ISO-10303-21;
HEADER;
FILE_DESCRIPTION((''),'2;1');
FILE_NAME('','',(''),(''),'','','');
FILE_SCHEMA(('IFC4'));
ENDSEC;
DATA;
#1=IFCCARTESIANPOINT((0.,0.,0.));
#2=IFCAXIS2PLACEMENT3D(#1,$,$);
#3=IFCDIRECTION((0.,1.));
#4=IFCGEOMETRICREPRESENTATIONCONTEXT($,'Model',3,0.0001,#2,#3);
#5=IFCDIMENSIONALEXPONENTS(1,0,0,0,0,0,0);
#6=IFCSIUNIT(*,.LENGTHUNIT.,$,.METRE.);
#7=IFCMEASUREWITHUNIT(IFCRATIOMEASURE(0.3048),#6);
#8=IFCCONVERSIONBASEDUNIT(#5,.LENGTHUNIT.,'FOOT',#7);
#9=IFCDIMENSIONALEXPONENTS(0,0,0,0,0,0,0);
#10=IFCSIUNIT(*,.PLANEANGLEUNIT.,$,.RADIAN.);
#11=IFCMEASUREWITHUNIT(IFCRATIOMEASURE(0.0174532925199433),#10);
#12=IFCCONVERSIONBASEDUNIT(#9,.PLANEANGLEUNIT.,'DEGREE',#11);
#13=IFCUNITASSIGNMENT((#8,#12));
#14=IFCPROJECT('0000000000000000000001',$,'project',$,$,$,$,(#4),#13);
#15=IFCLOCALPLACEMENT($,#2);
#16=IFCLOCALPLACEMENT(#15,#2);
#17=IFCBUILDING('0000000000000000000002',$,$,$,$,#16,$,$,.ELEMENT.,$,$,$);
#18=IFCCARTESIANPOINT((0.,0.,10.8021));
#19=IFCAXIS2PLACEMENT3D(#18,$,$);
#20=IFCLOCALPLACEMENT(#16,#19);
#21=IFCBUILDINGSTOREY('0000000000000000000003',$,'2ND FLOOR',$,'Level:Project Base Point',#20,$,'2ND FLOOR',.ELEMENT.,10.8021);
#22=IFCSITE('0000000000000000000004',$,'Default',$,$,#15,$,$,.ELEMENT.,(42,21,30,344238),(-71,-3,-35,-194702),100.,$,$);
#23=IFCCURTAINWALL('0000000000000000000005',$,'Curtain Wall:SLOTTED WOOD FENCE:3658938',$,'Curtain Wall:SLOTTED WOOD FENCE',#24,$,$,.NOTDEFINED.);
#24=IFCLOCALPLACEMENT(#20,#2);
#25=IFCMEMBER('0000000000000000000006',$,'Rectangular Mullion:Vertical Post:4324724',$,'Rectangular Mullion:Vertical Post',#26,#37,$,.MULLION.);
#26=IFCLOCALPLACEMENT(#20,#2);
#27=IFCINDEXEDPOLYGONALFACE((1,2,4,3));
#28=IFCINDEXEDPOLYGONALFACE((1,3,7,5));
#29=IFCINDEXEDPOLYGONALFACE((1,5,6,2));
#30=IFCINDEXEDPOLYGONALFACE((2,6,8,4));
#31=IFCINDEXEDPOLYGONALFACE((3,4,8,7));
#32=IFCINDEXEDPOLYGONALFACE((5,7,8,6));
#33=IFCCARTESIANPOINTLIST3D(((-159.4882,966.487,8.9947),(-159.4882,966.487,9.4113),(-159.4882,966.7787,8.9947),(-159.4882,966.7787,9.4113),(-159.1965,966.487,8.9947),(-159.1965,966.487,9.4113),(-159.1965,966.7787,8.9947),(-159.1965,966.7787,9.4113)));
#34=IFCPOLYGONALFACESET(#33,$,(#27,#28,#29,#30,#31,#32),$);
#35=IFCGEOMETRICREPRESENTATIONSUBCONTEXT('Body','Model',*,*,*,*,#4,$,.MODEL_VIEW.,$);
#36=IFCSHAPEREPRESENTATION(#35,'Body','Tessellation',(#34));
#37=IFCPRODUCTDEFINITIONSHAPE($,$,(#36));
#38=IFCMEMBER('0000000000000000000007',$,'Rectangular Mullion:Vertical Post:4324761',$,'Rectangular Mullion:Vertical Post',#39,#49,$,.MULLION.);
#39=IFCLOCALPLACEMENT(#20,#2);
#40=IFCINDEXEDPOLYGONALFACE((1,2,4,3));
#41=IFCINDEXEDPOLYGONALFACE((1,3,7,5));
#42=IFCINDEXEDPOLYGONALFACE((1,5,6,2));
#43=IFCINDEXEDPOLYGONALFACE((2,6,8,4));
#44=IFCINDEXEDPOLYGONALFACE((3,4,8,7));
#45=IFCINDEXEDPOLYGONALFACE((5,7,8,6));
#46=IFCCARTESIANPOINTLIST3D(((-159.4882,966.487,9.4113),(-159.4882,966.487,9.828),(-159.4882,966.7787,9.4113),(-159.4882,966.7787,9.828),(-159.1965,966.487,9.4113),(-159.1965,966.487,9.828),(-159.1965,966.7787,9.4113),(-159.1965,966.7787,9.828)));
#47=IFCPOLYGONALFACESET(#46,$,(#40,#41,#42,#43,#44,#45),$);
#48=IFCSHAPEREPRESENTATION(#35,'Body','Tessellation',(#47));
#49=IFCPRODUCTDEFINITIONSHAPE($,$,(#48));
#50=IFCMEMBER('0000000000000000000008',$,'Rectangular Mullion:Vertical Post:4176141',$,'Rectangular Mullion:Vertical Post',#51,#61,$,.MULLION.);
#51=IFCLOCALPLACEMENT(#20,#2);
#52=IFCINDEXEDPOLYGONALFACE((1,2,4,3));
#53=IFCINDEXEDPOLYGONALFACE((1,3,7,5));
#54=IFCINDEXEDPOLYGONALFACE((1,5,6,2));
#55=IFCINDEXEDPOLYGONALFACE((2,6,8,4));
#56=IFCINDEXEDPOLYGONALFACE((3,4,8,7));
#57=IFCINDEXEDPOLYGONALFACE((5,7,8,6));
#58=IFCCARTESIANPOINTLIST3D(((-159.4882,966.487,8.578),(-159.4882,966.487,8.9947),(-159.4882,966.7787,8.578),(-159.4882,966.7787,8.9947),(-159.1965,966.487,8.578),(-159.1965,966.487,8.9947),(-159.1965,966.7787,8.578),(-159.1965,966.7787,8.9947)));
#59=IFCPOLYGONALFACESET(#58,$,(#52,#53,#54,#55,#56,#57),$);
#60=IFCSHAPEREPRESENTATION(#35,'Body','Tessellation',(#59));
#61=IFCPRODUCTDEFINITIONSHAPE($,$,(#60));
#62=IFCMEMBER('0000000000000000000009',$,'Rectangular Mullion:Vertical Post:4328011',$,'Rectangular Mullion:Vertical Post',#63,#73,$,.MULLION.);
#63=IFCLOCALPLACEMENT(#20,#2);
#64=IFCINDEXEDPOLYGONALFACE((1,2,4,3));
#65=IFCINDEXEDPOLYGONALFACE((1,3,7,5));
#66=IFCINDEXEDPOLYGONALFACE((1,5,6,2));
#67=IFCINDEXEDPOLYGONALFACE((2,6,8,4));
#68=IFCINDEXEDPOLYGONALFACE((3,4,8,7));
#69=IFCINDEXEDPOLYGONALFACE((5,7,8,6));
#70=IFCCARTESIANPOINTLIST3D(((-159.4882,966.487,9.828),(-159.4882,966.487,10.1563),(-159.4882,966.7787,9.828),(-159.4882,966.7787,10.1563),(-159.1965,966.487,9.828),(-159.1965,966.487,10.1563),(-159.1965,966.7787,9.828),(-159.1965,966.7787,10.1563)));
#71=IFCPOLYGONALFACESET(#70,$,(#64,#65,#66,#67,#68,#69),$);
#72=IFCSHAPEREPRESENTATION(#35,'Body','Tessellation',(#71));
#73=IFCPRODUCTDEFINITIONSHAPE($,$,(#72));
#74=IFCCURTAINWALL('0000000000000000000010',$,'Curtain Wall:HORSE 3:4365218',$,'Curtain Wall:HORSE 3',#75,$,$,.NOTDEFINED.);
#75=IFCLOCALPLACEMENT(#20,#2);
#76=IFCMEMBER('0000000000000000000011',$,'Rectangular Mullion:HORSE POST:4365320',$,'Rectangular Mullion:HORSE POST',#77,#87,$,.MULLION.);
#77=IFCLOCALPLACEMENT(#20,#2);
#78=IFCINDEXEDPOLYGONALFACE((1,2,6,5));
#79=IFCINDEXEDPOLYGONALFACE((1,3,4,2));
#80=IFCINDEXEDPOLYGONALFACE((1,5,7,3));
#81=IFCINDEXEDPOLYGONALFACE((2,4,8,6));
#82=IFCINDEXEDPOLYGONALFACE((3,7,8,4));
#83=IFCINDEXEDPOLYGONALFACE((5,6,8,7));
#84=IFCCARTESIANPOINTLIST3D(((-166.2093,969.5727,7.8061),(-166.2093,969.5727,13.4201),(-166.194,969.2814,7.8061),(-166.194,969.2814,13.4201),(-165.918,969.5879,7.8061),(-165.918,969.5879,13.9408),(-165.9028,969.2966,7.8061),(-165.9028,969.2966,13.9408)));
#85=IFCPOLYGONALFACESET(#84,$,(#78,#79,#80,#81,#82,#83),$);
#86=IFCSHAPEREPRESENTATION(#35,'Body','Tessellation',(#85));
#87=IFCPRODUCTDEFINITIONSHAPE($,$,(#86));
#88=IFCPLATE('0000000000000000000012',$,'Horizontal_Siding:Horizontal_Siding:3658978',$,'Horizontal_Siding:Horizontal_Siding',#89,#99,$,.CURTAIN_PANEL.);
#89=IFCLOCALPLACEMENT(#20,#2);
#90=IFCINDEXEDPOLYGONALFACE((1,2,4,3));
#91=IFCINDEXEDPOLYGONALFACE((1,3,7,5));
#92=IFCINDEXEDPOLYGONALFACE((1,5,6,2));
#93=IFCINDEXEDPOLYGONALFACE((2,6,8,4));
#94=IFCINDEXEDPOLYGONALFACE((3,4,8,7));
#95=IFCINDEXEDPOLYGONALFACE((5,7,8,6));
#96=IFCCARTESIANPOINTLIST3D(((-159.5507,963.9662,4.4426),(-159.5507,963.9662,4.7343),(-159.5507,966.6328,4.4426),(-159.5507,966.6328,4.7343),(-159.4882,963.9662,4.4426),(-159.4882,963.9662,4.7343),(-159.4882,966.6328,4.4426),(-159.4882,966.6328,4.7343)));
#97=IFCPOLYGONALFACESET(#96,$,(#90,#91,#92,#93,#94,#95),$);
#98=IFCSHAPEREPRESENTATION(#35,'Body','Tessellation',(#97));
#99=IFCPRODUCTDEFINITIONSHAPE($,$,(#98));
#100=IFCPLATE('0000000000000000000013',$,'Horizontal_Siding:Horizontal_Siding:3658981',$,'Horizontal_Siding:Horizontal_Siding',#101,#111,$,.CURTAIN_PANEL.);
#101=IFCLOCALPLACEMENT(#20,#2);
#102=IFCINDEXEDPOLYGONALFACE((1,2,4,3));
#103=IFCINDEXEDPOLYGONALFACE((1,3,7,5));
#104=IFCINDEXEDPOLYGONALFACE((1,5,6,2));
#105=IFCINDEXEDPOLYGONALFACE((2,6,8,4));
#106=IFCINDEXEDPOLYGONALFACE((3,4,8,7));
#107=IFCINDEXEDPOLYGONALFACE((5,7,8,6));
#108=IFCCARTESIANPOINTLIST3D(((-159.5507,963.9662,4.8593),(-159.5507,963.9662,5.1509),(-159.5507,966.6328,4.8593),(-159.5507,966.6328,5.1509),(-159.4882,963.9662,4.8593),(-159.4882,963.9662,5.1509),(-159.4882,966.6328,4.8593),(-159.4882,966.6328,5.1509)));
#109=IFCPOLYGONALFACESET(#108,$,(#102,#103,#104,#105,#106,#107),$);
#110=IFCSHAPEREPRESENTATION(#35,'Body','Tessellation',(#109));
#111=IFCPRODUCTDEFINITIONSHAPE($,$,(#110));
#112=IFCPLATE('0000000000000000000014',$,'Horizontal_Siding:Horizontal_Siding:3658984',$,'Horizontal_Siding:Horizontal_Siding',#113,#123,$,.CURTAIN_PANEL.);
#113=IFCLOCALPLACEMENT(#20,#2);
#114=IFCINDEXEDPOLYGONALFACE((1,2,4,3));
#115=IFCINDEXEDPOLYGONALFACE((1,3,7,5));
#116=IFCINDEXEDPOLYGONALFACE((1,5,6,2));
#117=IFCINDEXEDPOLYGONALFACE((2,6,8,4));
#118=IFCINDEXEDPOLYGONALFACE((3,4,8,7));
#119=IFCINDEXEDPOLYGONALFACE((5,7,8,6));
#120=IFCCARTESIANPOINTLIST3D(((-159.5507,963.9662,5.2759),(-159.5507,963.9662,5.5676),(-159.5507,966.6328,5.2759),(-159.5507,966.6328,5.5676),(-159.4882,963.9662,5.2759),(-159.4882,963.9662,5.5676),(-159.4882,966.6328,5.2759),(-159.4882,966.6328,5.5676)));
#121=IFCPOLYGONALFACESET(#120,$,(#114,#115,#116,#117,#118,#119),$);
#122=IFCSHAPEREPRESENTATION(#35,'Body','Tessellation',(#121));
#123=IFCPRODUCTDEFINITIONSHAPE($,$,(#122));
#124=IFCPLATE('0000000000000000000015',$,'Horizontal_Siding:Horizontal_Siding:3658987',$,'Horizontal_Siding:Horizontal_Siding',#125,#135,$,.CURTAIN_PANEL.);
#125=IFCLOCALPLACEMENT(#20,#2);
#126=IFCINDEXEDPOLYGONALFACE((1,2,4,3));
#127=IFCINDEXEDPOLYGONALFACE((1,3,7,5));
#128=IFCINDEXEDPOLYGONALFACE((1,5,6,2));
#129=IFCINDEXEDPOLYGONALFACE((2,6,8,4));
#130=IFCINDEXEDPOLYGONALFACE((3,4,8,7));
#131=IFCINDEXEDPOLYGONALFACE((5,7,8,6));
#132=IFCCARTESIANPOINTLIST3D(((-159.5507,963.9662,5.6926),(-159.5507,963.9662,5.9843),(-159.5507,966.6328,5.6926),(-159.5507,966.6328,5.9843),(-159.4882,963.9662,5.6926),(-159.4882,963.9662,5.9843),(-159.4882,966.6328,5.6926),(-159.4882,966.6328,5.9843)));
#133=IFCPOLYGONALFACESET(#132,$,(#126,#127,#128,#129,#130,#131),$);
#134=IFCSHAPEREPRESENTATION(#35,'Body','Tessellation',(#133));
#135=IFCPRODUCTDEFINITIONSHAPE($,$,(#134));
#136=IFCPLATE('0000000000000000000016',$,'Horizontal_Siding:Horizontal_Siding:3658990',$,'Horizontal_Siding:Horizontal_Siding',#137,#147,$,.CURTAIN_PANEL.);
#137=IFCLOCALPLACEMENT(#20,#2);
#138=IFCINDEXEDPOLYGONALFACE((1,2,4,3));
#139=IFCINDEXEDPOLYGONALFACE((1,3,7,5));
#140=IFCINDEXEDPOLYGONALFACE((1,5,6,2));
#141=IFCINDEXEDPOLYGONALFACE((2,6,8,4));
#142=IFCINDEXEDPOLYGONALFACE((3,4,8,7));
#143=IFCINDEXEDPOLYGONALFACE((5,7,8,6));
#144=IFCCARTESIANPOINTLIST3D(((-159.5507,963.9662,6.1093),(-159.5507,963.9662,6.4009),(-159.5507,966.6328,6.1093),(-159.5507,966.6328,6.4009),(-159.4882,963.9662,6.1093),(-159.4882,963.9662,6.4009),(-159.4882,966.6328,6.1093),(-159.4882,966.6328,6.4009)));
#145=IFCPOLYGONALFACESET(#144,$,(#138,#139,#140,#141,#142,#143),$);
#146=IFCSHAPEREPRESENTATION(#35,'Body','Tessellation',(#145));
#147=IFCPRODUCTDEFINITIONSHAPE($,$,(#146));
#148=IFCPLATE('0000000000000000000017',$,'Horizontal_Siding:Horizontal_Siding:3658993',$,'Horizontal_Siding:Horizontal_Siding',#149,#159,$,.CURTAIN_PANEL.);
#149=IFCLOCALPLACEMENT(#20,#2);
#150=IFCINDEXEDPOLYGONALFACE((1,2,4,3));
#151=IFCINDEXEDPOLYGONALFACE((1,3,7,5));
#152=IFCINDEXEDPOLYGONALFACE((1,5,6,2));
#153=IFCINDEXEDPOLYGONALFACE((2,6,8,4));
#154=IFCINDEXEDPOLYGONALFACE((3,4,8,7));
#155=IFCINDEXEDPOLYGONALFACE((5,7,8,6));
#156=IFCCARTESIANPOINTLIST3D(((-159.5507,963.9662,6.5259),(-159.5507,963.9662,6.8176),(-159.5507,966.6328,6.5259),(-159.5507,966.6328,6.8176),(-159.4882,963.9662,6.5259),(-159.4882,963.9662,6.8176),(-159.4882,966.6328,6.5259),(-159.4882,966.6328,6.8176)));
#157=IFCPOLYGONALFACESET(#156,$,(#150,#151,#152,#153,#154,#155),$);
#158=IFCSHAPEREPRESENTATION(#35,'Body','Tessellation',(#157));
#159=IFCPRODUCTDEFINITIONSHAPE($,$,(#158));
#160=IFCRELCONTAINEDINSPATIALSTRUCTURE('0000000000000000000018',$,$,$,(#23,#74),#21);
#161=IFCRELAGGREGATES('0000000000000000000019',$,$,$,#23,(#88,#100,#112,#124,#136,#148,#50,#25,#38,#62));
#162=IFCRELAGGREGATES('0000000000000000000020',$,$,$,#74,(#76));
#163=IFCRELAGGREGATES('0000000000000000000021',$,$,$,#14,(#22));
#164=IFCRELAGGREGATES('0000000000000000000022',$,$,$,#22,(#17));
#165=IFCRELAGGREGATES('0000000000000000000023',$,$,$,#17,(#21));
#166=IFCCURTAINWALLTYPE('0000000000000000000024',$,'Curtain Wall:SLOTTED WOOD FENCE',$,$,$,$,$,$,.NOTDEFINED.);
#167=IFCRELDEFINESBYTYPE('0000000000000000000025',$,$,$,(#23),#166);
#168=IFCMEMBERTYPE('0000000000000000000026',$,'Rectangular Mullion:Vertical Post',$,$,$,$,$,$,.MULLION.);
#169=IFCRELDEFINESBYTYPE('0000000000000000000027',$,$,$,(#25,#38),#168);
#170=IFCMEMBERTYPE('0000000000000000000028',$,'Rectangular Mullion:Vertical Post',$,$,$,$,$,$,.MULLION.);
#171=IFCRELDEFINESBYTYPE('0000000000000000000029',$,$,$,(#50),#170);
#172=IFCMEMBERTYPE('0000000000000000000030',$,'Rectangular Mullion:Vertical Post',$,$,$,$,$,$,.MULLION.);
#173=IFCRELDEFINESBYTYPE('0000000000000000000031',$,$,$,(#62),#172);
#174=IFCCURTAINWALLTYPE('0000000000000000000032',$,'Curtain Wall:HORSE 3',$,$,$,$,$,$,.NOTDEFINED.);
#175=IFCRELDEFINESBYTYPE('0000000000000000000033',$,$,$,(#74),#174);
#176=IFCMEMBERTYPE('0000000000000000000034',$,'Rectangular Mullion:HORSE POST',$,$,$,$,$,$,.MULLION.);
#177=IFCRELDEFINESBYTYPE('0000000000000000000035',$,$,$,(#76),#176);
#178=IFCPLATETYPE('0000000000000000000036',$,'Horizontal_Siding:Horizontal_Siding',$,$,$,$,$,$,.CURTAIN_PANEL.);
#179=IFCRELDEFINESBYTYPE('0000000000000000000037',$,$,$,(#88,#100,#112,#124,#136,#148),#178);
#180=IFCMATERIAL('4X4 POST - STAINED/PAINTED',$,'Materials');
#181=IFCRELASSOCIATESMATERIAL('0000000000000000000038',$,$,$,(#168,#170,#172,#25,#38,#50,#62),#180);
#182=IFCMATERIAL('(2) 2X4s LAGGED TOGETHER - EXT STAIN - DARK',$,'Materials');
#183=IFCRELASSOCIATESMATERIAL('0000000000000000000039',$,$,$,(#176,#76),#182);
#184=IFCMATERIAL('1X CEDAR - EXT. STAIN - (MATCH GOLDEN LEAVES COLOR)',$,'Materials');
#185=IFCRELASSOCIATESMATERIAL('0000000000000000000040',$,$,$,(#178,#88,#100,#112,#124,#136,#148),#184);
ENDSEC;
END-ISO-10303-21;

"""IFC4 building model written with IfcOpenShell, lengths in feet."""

from ifc_helpers import new_model, entity, si_unit, converted_unit, direction, frame, frame_2d, origin, origin_2d_with_axis, place, context, subcontext, project, spatial, rectangle, extrude, clip, halfspace, source, transform, mapped, material, material_profile, profile_set, profile_usage, type_object, type_shapes, element, aggregate, save


model = new_model("IFC4")

# Units and contexts
model_context = context("Model", 3, precision=0.0001, world=origin(), true_north=direction((0.0, 1.0)))
body_context = subcontext(model_context, "Body", "Model", "MODEL_VIEW")
ifc_project = project(units=[converted_unit("LENGTHUNIT", "FOOT", entity("IfcRatioMeasure", 0.3048), si_unit("LENGTHUNIT", "METRE"), dimensions=[1, 0, 0, 0, 0, 0, 0]), converted_unit("PLANEANGLEUNIT", "DEGREE", entity("IfcRatioMeasure", 0.0174532925199433), si_unit("PLANEANGLEUNIT", "RADIAN"), dimensions=[0, 0, 0, 0, 0, 0, 0])], contexts=[model_context])

# Site, building, storey
site_placement = place(None, origin())
site = spatial("IfcSite", under=ifc_project, at=site_placement, Name="Default", CompositionType="ELEMENT", RefLatitude=(42, 21, 30, 344238), RefLongitude=(-71, -3, -35, -194702), RefElevation=100.0)
building_placement = place(site_placement, origin())
building = spatial("IfcBuilding", under=site, at=building_placement, CompositionType="ELEMENT")
storey_placement = place(building_placement, frame((0.0, 0.0, 10.8021)))
storey = spatial("IfcBuildingStorey", under=building, at=storey_placement, Name="2ND FLOOR", ObjectType="Level:Project Base Point", LongName="2ND FLOOR", CompositionType="ELEMENT", Elevation=10.8021)

# Curtain wall, members
curtain_wall_type_1 = type_object("IfcCurtainWallType", Name="Curtain Wall:SLOTTED WOOD FENCE", PredefinedType="NOTDEFINED")
curtain_wall_1_placement = place(storey_placement, frame((0.0, 0.0, -10.8021)))
curtain_wall_1 = element("IfcCurtainWall", 1, at=curtain_wall_1_placement, inside=storey, type_object=curtain_wall_type_1, Name="Curtain Wall:SLOTTED WOOD FENCE:3658938", ObjectType="Curtain Wall:SLOTTED WOOD FENCE", PredefinedType="NOTDEFINED")
ifc_material_1 = material(Name="4X4 POST - STAINED/PAINTED", Category="Materials")
ifc_material_profile_1 = material_profile(ifc_material_1, rectangle(XDim=0.2917, YDim=0.2917, at=origin_2d_with_axis()), Name="Vertical Post")
ifc_profile_set_1 = profile_set([ifc_material_profile_1], Name="Vertical Post")
member_type_1 = type_object("IfcMemberType", Name="Rectangular Mullion:Vertical Post", PredefinedType="MULLION", material=ifc_profile_set_1)
shared_shape_1 = source(origin(), body_context, "Body", "SweptSolid", [
    extrude(rectangle(XDim=0.2917, YDim=0.2917, at=origin_2d_with_axis()), frame((0.0, -0.2083, -0.4167), z_axis=(0.0, 0.0, 1.0), x_axis=(0.0, -1.0, 0.0)), (0.0, 0.0, 1.0), 0.4167),
])
type_shapes(member_type_1, [shared_shape_1])
ifc_profile_usage_1 = profile_usage(ifc_profile_set_1)
member_1_placement = place(storey_placement, frame((-159.5507, 966.6328, 8.9947), z_axis=(0.0, 0.0, -1.0), x_axis=(0.0, -1.0, 0.0)))
member_1 = element("IfcMember", 2, at=member_1_placement, type_object=member_type_1, material=ifc_profile_usage_1, Name="Rectangular Mullion:Vertical Post:4324724", ObjectType="Rectangular Mullion:Vertical Post", PredefinedType="MULLION", context=body_context, shape_type="MappedRepresentation", body=[
    mapped(shared_shape_1, transform((0.0, 0.0, 0.0), scale=1.0)),
])
ifc_profile_usage_2 = profile_usage(ifc_profile_set_1)
member_2_placement = place(storey_placement, frame((-159.5507, 966.6328, 9.4113), z_axis=(0.0, 0.0, -1.0), x_axis=(0.0, -1.0, 0.0)))
member_2 = element("IfcMember", 3, at=member_2_placement, type_object=member_type_1, material=ifc_profile_usage_2, Name="Rectangular Mullion:Vertical Post:4324761", ObjectType="Rectangular Mullion:Vertical Post", PredefinedType="MULLION", context=body_context, shape_type="MappedRepresentation", body=[
    mapped(shared_shape_1, transform((0.0, 0.0, 0.0), scale=1.0)),
])
ifc_profile_usage_3 = profile_usage(ifc_profile_set_1)
member_type_2 = type_object("IfcMemberType", Name="Rectangular Mullion:Vertical Post", PredefinedType="MULLION", material=ifc_profile_set_1)
shared_shape_2 = source(origin(), body_context, "Body", "SweptSolid", [
    extrude(rectangle(XDim=0.2917, YDim=0.2917, at=origin_2d_with_axis()), frame((0.0, -0.2083, -0.4167), z_axis=(0.0, 0.0, 1.0), x_axis=(0.0, -1.0, 0.0)), (0.0, 0.0, 1.0), 0.4167),
])
type_shapes(member_type_2, [shared_shape_2])
member_3_placement = place(storey_placement, frame((-159.5507, 966.6328, 8.578), z_axis=(0.0, 0.0, -1.0), x_axis=(0.0, -1.0, 0.0)))
member_3 = element("IfcMember", 4, at=member_3_placement, type_object=member_type_2, material=ifc_profile_usage_3, Name="Rectangular Mullion:Vertical Post:4176141", ObjectType="Rectangular Mullion:Vertical Post", PredefinedType="MULLION", context=body_context, shape_type="MappedRepresentation", body=[
    mapped(shared_shape_2, transform((0.0, 0.0, 0.0), scale=1.0)),
])
ifc_profile_usage_4 = profile_usage(ifc_profile_set_1)
member_type_3 = type_object("IfcMemberType", Name="Rectangular Mullion:Vertical Post", PredefinedType="MULLION", material=ifc_profile_set_1)
shared_shape_3 = source(origin(), body_context, "Body", "SweptSolid", [
    extrude(rectangle(XDim=0.2917, YDim=0.2917, at=origin_2d_with_axis()), frame((0.0, -0.2083, -0.3282), z_axis=(0.0, 0.0, 1.0), x_axis=(0.0, -1.0, 0.0)), (0.0, 0.0, 1.0), 0.3282),
])
type_shapes(member_type_3, [shared_shape_3])
member_4_placement = place(storey_placement, frame((-159.5507, 966.6328, 9.828), z_axis=(0.0, 0.0, -1.0), x_axis=(0.0, -1.0, 0.0)))
member_4 = element("IfcMember", 5, at=member_4_placement, type_object=member_type_3, material=ifc_profile_usage_4, Name="Rectangular Mullion:Vertical Post:4328011", ObjectType="Rectangular Mullion:Vertical Post", PredefinedType="MULLION", context=body_context, shape_type="MappedRepresentation", body=[
    mapped(shared_shape_3, transform((0.0, 0.0, 0.0), scale=1.0)),
])

# Curtain wall, member
curtain_wall_type_2 = type_object("IfcCurtainWallType", Name="Curtain Wall:HORSE 3", PredefinedType="NOTDEFINED")
curtain_wall_2_placement = place(storey_placement, frame((0.0, 0.0, -10.8021)))
curtain_wall_2 = element("IfcCurtainWall", 6, at=curtain_wall_2_placement, inside=storey, type_object=curtain_wall_type_2, Name="Curtain Wall:HORSE 3:4365218", ObjectType="Curtain Wall:HORSE 3", PredefinedType="NOTDEFINED")
ifc_material_2 = material(Name="(2) 2X4s LAGGED TOGETHER - EXT STAIN - DARK", Category="Materials")
ifc_material_profile_2 = material_profile(ifc_material_2, rectangle(XDim=0.2917, YDim=0.2917, at=frame_2d((0.0, 0.0), x_axis=(1.0, 0.0))), Name="HORSE POST")
ifc_profile_set_2 = profile_set([ifc_material_profile_2], Name="HORSE POST")
ifc_profile_usage_5 = profile_usage(ifc_profile_set_2)
member_type_4 = type_object("IfcMemberType", Name="Rectangular Mullion:HORSE POST", PredefinedType="MULLION", material=ifc_profile_set_2)
shared_shape_4 = source(origin(), body_context, "Body", "Clipping", [
    clip(extrude(rectangle(XDim=0.2917, YDim=0.2917, at=origin_2d_with_axis()), frame((-0.1458, 0.1458, -6.1347), z_axis=(0.0, 0.0, 1.0), x_axis=(0.0, -1.0, 0.0)), (0.0, 0.0, 1.0), 6.1347), halfspace(frame((0.0, -1.0, 0.0), z_axis=(-0.872455, 0.0, 0.488694), x_axis=(-0.488694, 0.0, -0.872455)), False)),
])
type_shapes(member_type_4, [shared_shape_4])
member_5_placement = place(storey_placement, frame((-165.9028, 969.2966, 13.9408), z_axis=(0.0, 0.0, 1.0), x_axis=(0.99863, 0.052336, 0.0)))
member_5 = element("IfcMember", 7, at=member_5_placement, type_object=member_type_4, material=ifc_profile_usage_5, Name="Rectangular Mullion:HORSE POST:4365320", ObjectType="Rectangular Mullion:HORSE POST", PredefinedType="MULLION", context=body_context, shape_type="MappedRepresentation", body=[
    mapped(shared_shape_4, transform((0.0, 0.0, 0.0), scale=1.0)),
])

# Plates
ifc_material_3 = material(Name="1X CEDAR - EXT. STAIN - (MATCH GOLDEN LEAVES COLOR)", Category="Materials")
plate_type_1 = type_object("IfcPlateType", Name="Horizontal_Siding:Horizontal_Siding", PredefinedType="CURTAIN_PANEL", material=ifc_material_3)
shared_shape_5 = source(origin(), body_context, "Body", "SweptSolid", [
    extrude(rectangle(XDim=2.6667, YDim=0.0625, at=origin_2d_with_axis()), frame((1.3333, 0.0312, 0.0), z_axis=(0.0, 0.0, 1.0), x_axis=(-1.0, 0.0, 0.0)), (0.0, 0.0, 1.0), 0.2917),
])
type_shapes(plate_type_1, [shared_shape_5])
plate_1_placement = place(curtain_wall_1_placement, frame((-159.5507, 966.6328, 15.2447), z_axis=(0.0, 0.0, 1.0), x_axis=(0.0, -1.0, 0.0)))
plate_1 = element("IfcPlate", 8, at=plate_1_placement, type_object=plate_type_1, material=ifc_material_3, Name="Horizontal_Siding:Horizontal_Siding:3658978", ObjectType="Horizontal_Siding:Horizontal_Siding", PredefinedType="CURTAIN_PANEL", context=body_context, shape_type="MappedRepresentation", body=[
    mapped(shared_shape_5, transform((0.0, 0.0, 0.0), scale=1.0)),
])
plate_2_placement = place(curtain_wall_1_placement, frame((-159.5507, 966.6328, 15.6613), z_axis=(0.0, 0.0, 1.0), x_axis=(0.0, -1.0, 0.0)))
plate_2 = element("IfcPlate", 9, at=plate_2_placement, type_object=plate_type_1, material=ifc_material_3, Name="Horizontal_Siding:Horizontal_Siding:3658981", ObjectType="Horizontal_Siding:Horizontal_Siding", PredefinedType="CURTAIN_PANEL", context=body_context, shape_type="MappedRepresentation", body=[
    mapped(shared_shape_5, transform((0.0, 0.0, 0.0), scale=1.0)),
])
plate_3_placement = place(curtain_wall_1_placement, frame((-159.5507, 966.6328, 16.078), z_axis=(0.0, 0.0, 1.0), x_axis=(0.0, -1.0, 0.0)))
plate_3 = element("IfcPlate", 10, at=plate_3_placement, type_object=plate_type_1, material=ifc_material_3, Name="Horizontal_Siding:Horizontal_Siding:3658984", ObjectType="Horizontal_Siding:Horizontal_Siding", PredefinedType="CURTAIN_PANEL", context=body_context, shape_type="MappedRepresentation", body=[
    mapped(shared_shape_5, transform((0.0, 0.0, 0.0), scale=1.0)),
])
plate_4_placement = place(curtain_wall_1_placement, frame((-159.5507, 966.6328, 16.4947), z_axis=(0.0, 0.0, 1.0), x_axis=(0.0, -1.0, 0.0)))
plate_4 = element("IfcPlate", 11, at=plate_4_placement, type_object=plate_type_1, material=ifc_material_3, Name="Horizontal_Siding:Horizontal_Siding:3658987", ObjectType="Horizontal_Siding:Horizontal_Siding", PredefinedType="CURTAIN_PANEL", context=body_context, shape_type="MappedRepresentation", body=[
    mapped(shared_shape_5, transform((0.0, 0.0, 0.0), scale=1.0)),
])
plate_5_placement = place(curtain_wall_1_placement, frame((-159.5507, 966.6328, 16.9113), z_axis=(0.0, 0.0, 1.0), x_axis=(0.0, -1.0, 0.0)))
plate_5 = element("IfcPlate", 12, at=plate_5_placement, type_object=plate_type_1, material=ifc_material_3, Name="Horizontal_Siding:Horizontal_Siding:3658990", ObjectType="Horizontal_Siding:Horizontal_Siding", PredefinedType="CURTAIN_PANEL", context=body_context, shape_type="MappedRepresentation", body=[
    mapped(shared_shape_5, transform((0.0, 0.0, 0.0), scale=1.0)),
])
plate_6_placement = place(curtain_wall_1_placement, frame((-159.5507, 966.6328, 17.328), z_axis=(0.0, 0.0, 1.0), x_axis=(0.0, -1.0, 0.0)))
plate_6 = element("IfcPlate", 13, at=plate_6_placement, type_object=plate_type_1, material=ifc_material_3, Name="Horizontal_Siding:Horizontal_Siding:3658993", ObjectType="Horizontal_Siding:Horizontal_Siding", PredefinedType="CURTAIN_PANEL", context=body_context, shape_type="MappedRepresentation", body=[
    mapped(shared_shape_5, transform((0.0, 0.0, 0.0), scale=1.0)),
])
aggregate(curtain_wall_1, [plate_1, plate_2, plate_3, plate_4, plate_5, plate_6, member_3, member_1, member_2, member_4])
aggregate(curtain_wall_2, [member_5])

save(model, "model.ifc")
